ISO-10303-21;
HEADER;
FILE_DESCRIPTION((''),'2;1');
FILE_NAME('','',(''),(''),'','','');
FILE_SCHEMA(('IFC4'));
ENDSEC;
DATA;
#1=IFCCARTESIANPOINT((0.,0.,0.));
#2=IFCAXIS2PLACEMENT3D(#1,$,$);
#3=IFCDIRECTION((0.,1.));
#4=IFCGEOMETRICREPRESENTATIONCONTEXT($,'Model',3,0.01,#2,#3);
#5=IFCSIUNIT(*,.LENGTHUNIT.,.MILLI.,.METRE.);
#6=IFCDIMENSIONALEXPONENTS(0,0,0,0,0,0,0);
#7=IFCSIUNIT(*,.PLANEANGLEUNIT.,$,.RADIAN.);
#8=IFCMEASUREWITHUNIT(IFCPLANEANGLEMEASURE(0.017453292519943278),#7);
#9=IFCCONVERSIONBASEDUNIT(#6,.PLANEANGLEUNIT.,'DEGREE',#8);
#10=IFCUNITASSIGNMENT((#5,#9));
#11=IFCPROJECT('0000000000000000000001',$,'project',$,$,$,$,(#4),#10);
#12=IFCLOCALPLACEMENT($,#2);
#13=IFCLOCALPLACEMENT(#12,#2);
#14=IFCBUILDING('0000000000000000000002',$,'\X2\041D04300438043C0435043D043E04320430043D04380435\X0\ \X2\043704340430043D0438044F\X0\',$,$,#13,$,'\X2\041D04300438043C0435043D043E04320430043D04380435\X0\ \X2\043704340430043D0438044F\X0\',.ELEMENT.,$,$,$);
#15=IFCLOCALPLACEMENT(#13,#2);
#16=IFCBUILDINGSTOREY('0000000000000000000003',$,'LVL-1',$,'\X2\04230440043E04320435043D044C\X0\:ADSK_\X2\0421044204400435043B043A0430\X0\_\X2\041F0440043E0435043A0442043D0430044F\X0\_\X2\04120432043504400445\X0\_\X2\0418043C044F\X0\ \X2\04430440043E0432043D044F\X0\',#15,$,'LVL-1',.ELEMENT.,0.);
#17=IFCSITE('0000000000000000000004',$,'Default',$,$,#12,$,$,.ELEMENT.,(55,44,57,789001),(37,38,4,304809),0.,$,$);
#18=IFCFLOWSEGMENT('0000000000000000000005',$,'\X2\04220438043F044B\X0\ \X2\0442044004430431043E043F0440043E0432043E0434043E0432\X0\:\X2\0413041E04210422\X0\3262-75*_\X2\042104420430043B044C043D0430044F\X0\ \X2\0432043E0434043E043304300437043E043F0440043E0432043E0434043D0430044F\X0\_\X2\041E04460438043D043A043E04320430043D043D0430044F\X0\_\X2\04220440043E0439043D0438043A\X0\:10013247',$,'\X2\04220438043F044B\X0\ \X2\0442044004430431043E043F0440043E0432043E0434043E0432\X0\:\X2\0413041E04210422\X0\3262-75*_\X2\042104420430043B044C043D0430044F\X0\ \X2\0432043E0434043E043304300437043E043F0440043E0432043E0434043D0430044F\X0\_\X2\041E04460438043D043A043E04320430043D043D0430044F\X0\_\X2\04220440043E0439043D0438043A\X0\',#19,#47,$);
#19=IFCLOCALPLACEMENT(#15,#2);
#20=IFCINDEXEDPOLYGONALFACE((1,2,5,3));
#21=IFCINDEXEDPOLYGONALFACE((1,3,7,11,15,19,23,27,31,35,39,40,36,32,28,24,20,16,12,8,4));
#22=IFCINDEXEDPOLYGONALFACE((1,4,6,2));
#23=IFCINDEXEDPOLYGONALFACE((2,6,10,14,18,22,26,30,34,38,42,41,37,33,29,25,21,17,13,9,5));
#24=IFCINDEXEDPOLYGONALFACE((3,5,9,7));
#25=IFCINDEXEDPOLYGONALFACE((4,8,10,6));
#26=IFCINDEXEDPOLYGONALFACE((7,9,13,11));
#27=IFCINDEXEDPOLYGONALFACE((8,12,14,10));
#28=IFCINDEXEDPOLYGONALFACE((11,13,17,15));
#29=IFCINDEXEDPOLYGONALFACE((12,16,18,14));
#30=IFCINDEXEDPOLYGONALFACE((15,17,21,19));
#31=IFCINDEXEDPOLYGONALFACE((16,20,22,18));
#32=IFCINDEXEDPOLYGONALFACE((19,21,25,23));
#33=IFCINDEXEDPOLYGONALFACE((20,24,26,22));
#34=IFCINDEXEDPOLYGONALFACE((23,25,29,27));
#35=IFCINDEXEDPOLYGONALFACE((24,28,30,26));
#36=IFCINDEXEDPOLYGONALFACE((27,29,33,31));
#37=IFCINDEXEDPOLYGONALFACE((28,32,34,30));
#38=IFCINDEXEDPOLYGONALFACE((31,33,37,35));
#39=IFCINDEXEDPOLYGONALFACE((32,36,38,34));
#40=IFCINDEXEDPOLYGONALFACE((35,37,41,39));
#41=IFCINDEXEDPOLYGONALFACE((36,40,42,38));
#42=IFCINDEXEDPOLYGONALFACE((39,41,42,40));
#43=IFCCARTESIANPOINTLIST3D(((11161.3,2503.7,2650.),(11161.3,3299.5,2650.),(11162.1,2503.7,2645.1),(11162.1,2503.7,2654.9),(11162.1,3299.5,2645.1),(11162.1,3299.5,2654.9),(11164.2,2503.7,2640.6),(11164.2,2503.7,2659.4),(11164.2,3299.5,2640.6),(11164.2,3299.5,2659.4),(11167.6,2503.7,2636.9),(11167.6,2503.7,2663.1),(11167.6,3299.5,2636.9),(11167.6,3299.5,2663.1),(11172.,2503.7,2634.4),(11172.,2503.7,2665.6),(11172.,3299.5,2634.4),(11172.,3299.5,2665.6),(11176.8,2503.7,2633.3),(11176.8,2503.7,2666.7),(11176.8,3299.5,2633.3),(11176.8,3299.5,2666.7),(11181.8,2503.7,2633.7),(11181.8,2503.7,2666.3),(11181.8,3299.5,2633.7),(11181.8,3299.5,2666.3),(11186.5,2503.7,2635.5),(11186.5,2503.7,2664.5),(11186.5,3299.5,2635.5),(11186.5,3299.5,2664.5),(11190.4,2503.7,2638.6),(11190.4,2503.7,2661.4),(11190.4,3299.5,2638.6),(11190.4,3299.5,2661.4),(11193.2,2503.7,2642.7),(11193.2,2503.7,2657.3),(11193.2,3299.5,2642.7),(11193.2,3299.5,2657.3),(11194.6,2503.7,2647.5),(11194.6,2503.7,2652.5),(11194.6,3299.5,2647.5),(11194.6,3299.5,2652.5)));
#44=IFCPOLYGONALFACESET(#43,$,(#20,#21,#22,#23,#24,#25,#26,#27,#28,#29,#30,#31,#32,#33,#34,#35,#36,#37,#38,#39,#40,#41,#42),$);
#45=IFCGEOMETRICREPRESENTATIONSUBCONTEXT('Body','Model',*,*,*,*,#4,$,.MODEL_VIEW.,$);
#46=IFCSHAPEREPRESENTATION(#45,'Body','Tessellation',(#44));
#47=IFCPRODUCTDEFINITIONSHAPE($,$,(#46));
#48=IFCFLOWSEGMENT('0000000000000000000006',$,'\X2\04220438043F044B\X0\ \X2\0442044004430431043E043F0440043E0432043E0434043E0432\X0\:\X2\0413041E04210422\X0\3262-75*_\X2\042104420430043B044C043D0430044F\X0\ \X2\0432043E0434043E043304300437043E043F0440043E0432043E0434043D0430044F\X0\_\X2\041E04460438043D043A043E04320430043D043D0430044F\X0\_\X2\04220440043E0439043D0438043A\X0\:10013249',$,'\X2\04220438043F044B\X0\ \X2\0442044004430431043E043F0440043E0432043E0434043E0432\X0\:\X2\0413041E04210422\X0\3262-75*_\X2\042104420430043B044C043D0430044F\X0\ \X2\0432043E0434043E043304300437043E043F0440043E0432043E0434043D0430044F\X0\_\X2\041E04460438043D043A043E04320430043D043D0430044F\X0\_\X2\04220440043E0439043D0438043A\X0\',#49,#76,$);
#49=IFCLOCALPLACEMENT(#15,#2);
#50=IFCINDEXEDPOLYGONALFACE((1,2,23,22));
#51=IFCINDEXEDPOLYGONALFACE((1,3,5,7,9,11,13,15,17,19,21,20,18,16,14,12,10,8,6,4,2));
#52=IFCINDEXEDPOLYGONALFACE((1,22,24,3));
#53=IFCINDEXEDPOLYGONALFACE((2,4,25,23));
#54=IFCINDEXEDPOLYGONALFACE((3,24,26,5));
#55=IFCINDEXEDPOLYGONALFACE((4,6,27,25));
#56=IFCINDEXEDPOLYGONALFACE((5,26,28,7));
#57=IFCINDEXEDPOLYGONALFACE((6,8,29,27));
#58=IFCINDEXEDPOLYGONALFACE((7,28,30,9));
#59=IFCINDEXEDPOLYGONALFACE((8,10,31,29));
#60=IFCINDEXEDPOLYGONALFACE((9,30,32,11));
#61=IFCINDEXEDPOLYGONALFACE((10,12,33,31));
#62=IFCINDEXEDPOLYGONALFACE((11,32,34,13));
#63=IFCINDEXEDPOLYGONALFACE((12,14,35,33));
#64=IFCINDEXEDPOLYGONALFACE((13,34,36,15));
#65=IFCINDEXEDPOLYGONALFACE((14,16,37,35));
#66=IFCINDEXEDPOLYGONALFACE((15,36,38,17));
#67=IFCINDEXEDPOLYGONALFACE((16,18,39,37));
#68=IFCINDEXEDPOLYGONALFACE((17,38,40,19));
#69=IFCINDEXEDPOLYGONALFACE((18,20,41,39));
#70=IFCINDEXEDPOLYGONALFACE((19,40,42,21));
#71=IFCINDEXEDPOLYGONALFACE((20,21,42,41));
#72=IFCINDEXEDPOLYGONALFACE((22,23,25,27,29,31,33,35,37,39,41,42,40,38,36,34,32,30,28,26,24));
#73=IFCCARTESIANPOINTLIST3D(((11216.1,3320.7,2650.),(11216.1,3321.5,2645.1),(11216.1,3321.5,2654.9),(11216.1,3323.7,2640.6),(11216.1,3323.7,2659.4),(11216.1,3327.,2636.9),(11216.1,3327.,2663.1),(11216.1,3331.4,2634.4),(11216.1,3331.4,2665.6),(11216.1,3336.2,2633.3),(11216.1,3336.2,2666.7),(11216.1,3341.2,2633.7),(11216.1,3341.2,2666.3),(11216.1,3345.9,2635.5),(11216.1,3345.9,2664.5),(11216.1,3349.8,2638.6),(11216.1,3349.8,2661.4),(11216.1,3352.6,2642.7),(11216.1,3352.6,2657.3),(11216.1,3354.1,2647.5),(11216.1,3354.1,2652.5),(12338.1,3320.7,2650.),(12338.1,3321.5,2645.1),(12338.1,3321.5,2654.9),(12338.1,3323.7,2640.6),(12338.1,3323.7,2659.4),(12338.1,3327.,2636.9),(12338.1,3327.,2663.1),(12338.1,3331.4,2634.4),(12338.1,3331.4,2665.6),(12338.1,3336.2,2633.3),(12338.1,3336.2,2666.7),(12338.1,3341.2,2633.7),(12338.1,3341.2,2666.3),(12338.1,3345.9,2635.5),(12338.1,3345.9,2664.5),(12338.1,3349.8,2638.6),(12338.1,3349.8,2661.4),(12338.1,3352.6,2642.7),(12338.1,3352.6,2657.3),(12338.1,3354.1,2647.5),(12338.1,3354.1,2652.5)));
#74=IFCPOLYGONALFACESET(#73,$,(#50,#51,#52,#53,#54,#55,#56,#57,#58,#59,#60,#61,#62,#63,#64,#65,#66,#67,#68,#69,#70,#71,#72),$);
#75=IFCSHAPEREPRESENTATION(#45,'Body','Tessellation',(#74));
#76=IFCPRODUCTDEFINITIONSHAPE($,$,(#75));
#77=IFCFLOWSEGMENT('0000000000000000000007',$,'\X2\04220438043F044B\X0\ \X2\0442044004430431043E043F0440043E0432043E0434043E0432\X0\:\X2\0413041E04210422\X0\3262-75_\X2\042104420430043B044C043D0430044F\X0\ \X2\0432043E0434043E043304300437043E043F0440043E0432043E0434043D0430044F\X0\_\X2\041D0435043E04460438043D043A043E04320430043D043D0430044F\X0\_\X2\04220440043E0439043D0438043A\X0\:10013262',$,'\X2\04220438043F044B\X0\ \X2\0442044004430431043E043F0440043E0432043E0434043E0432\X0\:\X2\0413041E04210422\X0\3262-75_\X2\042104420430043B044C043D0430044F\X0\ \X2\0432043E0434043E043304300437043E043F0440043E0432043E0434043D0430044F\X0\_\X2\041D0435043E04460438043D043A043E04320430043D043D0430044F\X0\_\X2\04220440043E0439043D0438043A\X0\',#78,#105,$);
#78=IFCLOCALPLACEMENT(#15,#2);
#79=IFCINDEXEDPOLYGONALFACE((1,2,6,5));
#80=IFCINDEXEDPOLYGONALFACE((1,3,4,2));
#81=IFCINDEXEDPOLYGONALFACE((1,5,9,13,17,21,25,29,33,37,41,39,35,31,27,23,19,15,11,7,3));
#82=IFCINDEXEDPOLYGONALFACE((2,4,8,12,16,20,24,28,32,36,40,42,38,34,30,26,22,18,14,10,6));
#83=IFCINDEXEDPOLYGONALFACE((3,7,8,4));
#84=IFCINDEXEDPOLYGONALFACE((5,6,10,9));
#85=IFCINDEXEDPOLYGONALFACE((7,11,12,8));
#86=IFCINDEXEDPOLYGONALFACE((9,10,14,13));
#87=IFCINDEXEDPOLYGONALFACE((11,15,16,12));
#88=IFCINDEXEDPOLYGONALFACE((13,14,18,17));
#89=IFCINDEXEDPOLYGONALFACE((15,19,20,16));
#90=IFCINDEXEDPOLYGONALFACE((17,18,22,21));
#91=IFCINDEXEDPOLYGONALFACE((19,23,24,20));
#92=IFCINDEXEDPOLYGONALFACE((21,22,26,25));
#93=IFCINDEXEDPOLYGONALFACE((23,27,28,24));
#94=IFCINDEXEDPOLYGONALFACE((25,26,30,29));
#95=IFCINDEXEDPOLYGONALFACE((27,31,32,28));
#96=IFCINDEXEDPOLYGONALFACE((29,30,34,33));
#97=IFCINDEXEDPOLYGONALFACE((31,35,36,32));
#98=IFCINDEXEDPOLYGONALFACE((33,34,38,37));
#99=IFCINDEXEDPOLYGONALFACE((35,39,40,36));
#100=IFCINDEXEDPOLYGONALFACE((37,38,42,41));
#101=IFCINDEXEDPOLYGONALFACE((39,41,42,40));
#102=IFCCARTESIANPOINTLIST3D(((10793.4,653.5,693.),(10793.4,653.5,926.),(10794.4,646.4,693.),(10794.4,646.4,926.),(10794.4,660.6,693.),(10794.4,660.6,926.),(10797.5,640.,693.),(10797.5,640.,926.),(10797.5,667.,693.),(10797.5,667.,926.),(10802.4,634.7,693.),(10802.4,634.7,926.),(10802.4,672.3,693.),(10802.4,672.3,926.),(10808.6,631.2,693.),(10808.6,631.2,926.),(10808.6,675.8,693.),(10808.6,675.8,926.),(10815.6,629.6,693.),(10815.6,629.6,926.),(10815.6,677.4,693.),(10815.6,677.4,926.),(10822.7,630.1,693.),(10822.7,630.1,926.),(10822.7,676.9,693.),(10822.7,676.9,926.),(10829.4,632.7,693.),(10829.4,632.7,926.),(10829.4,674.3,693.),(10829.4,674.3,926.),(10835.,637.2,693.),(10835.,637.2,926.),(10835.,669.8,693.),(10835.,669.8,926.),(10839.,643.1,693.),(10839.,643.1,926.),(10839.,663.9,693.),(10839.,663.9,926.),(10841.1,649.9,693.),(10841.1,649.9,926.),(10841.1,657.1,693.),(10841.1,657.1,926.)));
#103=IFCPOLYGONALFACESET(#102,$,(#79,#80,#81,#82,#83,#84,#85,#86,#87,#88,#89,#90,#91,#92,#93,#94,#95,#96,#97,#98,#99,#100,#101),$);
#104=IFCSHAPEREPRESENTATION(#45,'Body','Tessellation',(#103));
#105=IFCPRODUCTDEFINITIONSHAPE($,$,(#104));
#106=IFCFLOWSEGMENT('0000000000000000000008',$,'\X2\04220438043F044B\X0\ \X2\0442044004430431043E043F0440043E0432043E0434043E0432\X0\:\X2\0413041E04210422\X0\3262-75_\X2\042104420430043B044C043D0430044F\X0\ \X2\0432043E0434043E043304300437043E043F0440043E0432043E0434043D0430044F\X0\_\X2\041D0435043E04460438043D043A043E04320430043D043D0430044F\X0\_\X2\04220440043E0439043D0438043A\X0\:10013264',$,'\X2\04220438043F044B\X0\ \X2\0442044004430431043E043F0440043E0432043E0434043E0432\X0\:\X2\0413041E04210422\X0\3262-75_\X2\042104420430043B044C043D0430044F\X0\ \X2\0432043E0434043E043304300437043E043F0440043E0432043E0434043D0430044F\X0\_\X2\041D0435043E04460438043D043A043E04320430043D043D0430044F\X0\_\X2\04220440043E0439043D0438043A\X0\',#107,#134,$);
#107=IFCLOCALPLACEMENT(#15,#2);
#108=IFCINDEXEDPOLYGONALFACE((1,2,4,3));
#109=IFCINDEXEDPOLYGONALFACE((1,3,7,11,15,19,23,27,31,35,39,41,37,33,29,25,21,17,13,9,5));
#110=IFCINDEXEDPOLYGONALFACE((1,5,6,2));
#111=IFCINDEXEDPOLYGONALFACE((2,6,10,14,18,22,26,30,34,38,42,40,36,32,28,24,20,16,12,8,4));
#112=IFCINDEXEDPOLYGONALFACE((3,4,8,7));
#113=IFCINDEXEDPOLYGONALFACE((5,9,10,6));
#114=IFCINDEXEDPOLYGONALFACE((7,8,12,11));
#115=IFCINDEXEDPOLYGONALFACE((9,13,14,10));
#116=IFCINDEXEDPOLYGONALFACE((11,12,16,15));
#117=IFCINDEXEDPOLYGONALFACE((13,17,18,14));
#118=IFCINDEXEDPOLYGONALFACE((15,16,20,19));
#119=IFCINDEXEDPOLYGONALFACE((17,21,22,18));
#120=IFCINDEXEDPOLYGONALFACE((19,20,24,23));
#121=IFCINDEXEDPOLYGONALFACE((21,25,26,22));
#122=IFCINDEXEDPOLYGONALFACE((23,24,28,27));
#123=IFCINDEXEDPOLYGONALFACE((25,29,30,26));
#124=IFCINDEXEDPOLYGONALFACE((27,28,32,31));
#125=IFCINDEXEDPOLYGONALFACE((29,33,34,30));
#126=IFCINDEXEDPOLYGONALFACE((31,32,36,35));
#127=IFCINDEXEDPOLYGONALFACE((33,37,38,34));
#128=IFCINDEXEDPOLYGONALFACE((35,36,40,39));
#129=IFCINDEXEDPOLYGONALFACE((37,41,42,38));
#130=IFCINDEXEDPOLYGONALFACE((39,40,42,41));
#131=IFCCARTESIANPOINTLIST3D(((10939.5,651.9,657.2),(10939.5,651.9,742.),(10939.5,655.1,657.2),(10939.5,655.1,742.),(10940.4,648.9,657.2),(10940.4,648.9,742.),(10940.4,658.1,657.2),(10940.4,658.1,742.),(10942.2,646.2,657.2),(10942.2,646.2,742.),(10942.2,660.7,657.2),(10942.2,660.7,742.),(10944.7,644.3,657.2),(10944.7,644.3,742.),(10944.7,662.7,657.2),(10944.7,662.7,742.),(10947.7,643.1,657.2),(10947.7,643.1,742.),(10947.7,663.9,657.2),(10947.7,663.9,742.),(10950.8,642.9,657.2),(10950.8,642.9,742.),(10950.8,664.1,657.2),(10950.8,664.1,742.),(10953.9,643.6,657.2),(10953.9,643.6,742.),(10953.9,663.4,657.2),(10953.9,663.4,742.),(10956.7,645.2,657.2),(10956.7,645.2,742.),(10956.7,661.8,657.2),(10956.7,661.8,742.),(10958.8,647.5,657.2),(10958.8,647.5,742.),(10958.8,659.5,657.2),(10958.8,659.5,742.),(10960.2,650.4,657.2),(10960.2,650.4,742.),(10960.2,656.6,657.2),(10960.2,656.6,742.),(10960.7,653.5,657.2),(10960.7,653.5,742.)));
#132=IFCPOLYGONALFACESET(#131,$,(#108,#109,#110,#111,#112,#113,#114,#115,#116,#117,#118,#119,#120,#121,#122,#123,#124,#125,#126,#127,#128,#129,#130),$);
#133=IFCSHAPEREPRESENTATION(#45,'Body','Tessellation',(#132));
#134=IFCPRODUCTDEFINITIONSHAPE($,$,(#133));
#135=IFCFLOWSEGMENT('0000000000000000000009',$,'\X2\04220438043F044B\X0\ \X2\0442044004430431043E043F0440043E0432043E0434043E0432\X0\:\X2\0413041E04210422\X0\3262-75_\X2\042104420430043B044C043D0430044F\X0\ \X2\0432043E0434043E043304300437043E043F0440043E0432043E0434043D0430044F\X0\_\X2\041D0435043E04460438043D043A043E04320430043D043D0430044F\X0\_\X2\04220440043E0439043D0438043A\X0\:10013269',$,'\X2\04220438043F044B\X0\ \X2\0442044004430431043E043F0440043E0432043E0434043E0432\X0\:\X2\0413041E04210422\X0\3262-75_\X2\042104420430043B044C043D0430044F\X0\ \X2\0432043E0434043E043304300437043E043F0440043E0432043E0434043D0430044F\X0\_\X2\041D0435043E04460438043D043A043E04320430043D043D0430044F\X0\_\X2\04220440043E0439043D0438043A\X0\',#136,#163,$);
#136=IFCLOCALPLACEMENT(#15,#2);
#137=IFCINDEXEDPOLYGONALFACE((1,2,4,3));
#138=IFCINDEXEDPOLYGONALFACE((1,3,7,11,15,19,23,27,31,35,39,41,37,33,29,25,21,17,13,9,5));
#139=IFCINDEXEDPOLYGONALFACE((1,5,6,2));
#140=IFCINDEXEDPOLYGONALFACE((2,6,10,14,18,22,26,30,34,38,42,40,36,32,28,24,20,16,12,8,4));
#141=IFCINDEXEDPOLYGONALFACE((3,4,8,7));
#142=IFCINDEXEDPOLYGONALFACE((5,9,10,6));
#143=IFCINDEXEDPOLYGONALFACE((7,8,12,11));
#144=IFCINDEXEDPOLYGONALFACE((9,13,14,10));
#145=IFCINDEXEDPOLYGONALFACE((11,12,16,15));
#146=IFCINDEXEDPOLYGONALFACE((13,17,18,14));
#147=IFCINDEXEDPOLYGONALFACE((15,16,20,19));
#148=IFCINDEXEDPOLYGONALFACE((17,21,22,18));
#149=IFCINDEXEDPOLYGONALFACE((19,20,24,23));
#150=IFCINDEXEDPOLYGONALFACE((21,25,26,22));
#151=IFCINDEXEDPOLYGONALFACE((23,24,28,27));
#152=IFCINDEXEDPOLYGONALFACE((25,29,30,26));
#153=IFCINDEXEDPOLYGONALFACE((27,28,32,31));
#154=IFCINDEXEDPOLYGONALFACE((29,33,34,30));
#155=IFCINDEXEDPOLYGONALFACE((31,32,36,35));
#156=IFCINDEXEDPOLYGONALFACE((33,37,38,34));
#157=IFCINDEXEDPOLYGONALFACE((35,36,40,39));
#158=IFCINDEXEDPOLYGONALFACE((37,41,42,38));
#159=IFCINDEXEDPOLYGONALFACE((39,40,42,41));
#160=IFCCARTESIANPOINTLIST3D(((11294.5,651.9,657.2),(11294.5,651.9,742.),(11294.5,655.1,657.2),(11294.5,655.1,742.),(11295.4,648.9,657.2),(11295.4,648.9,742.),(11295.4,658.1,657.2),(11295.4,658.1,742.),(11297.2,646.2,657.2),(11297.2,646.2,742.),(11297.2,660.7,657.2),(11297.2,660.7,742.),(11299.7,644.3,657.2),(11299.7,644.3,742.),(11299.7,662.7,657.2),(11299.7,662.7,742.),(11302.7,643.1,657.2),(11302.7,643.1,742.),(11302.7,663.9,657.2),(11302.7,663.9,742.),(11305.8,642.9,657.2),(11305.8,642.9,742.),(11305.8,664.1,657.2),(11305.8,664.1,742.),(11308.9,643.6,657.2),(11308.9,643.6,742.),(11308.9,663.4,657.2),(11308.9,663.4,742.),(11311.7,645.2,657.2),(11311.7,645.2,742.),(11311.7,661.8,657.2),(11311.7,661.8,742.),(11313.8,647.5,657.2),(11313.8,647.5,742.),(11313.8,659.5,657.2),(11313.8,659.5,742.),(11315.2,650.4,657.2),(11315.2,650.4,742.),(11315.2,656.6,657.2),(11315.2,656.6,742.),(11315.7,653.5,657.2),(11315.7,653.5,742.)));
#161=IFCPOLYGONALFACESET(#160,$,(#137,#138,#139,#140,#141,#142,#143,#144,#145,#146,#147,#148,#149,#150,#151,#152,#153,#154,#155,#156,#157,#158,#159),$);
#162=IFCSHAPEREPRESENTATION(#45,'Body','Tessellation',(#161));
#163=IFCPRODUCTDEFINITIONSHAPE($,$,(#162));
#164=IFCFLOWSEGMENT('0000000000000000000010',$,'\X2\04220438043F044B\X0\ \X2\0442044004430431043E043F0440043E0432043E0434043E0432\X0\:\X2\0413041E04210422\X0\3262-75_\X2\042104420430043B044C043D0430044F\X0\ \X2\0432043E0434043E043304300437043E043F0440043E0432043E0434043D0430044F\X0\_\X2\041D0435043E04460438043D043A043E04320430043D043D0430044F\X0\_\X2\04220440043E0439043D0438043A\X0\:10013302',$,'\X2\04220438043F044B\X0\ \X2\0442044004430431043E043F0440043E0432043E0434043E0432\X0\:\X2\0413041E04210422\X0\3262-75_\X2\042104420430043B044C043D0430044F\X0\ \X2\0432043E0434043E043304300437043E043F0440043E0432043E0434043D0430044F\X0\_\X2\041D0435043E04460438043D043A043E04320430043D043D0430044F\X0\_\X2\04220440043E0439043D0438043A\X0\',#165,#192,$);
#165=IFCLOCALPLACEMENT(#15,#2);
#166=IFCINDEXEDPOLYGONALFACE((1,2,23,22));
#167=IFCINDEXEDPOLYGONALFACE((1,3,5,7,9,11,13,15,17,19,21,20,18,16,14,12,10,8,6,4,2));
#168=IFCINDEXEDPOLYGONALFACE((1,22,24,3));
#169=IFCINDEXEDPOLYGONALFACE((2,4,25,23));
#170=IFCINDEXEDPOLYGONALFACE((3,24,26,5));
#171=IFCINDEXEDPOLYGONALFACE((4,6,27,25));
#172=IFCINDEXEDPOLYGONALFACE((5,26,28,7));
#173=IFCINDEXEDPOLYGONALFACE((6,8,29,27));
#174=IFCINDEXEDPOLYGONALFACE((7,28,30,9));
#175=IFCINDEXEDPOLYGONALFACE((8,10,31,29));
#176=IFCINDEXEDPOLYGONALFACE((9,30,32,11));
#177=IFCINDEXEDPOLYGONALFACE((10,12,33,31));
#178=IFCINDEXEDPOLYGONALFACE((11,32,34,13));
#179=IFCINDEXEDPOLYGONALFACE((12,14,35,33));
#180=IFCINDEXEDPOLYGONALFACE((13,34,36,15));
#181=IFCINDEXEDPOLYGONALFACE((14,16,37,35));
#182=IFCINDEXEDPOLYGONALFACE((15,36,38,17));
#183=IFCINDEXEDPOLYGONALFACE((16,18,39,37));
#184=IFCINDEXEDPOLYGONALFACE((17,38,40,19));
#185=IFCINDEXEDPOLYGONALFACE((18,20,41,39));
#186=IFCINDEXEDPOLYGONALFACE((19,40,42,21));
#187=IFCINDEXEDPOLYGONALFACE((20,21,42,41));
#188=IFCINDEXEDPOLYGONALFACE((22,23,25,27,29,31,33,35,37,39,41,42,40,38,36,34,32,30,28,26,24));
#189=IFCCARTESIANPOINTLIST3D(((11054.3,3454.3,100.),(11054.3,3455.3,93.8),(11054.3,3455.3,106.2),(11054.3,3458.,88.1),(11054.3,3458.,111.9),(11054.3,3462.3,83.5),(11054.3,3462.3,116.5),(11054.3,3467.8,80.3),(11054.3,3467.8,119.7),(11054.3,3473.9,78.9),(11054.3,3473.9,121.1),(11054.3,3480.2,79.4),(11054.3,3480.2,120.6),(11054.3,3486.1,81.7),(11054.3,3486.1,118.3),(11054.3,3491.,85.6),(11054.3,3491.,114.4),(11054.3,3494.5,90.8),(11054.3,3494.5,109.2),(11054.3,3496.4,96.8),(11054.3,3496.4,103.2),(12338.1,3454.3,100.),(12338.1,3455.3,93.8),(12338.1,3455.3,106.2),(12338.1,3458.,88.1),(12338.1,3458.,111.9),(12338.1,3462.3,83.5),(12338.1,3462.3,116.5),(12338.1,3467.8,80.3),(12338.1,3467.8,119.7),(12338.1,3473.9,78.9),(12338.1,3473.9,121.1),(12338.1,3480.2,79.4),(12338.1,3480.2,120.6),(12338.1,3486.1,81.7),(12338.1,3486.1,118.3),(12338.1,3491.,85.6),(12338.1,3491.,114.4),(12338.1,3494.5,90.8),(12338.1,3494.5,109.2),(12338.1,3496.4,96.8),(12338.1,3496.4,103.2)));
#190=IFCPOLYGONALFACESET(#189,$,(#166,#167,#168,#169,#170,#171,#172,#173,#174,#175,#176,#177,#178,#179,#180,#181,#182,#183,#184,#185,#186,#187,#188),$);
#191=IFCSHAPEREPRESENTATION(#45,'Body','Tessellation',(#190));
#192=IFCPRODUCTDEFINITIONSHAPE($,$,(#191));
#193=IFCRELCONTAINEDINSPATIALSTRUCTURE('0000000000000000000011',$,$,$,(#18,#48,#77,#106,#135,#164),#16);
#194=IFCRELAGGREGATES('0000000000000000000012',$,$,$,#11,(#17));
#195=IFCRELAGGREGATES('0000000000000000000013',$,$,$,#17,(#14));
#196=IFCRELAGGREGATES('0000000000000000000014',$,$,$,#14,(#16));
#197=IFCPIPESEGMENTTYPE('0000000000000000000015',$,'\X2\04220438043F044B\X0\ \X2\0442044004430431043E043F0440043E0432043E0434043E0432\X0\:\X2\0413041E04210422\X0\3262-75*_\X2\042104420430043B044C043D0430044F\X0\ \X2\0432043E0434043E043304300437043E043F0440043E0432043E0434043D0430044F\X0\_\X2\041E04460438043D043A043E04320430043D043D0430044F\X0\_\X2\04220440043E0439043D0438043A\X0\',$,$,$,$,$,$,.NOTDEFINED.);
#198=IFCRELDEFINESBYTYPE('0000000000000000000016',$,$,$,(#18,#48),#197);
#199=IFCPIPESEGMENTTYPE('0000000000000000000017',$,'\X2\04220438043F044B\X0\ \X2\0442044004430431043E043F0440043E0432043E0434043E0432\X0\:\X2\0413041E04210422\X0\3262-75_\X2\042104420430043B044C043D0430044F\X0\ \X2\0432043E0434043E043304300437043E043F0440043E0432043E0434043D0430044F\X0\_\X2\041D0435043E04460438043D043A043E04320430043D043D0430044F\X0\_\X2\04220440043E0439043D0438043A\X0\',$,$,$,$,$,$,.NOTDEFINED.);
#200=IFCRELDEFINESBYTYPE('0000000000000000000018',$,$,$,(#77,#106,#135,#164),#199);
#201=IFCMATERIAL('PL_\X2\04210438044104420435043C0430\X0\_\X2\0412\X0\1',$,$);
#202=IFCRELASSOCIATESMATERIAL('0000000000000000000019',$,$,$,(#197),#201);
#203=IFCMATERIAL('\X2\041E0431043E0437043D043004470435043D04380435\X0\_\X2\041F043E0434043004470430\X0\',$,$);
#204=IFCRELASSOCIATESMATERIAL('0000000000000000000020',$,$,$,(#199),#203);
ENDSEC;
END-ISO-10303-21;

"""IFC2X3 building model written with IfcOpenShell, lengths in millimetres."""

from ifc_helpers import new_model, entity, si_unit, converted_unit, direction, frame, frame_2d, origin, origin_2d_with_axis, place, context, subcontext, project, spatial, circle, extrude, material, type_object, element, save


model = new_model("IFC2X3")

# Units and contexts
model_context = context("Model", 3, precision=0.01, world=origin(), true_north=direction((0.0, 1.0)))
body_context = subcontext(model_context, "Body", "Model", "MODEL_VIEW")
ifc_project = project(units=[si_unit("LENGTHUNIT", "METRE", prefix="MILLI"), converted_unit("PLANEANGLEUNIT", "DEGREE", entity("IfcPlaneAngleMeasure", 0.017453292519943278), si_unit("PLANEANGLEUNIT", "RADIAN"), dimensions=[0, 0, 0, 0, 0, 0, 0])], contexts=[model_context])

# Site, building, storey
site_placement = place(None, origin())
site = spatial("IfcSite", under=ifc_project, at=site_placement, Name="Default", CompositionType="ELEMENT", RefLatitude=(55, 44, 57, 789001), RefLongitude=(37, 38, 4, 304809), RefElevation=0.0)
building_placement = place(site_placement, origin())
building = spatial("IfcBuilding", under=site, at=building_placement, Name="Наименование здания", LongName="Наименование здания", CompositionType="ELEMENT")
storey_placement = place(building_placement, origin())
storey = spatial("IfcBuildingStorey", under=building, at=storey_placement, Name="LVL-1", ObjectType="Уровень:ADSK_Стрелка_Проектная_Вверх_Имя уровня", LongName="LVL-1", CompositionType="ELEMENT", Elevation=0.0)

# Flow segments
ifc_material_1 = material(Name="PL_Система_В1")
pipe_segment_type_1 = type_object("IfcPipeSegmentType", Name="Типы трубопроводов:ГОСТ3262-75*_Стальная водогазопроводная_Оцинкованная_Тройник", PredefinedType="NOTDEFINED", material=ifc_material_1)
flow_segment_1_placement = place(storey_placement, origin())
element("IfcFlowSegment", 1, at=flow_segment_1_placement, inside=storey, type_object=pipe_segment_type_1, Name="Типы трубопроводов:ГОСТ3262-75*_Стальная водогазопроводная_Оцинкованная_Тройник:10013247", ObjectType="Типы трубопроводов:ГОСТ3262-75*_Стальная водогазопроводная_Оцинкованная_Тройник", context=body_context, shape_type="SweptSolid", body=[
    extrude(circle(Radius=16.8, at=frame_2d((0.0, 0.0), x_axis=(1.0, 0.0))), frame((11178.1, 2503.7, 2650.0), z_axis=(0.0, 1.0, 0.0), x_axis=(-1.0, 0.0, 0.0)), (0.0, 0.0, 1.0), 795.8),
])
flow_segment_2_placement = place(storey_placement, origin())
element("IfcFlowSegment", 2, at=flow_segment_2_placement, inside=storey, type_object=pipe_segment_type_1, Name="Типы трубопроводов:ГОСТ3262-75*_Стальная водогазопроводная_Оцинкованная_Тройник:10013249", ObjectType="Типы трубопроводов:ГОСТ3262-75*_Стальная водогазопроводная_Оцинкованная_Тройник", context=body_context, shape_type="SweptSolid", body=[
    extrude(circle(Radius=16.8, at=origin_2d_with_axis()), frame((11216.1, 3337.5, 2650.0), z_axis=(1.0, 0.0, 0.0), x_axis=(0.0, -1.0, 0.0)), (0.0, 0.0, 1.0), 1122.0),
])
ifc_material_2 = material(Name="Обозначение_Подача")
pipe_segment_type_2 = type_object("IfcPipeSegmentType", Name="Типы трубопроводов:ГОСТ3262-75_Стальная водогазопроводная_Неоцинкованная_Тройник", PredefinedType="NOTDEFINED", material=ifc_material_2)
flow_segment_3_placement = place(storey_placement, origin())
element("IfcFlowSegment", 3, at=flow_segment_3_placement, inside=storey, type_object=pipe_segment_type_2, Name="Типы трубопроводов:ГОСТ3262-75_Стальная водогазопроводная_Неоцинкованная_Тройник:10013262", ObjectType="Типы трубопроводов:ГОСТ3262-75_Стальная водогазопроводная_Неоцинкованная_Тройник", context=body_context, shape_type="SweptSolid", body=[
    extrude(circle(Radius=24.0, at=origin_2d_with_axis()), frame((10817.4, 653.5, 693.0), z_axis=(0.0, 0.0, 1.0), x_axis=(-1.0, 0.0, 0.0)), (0.0, 0.0, 1.0), 233.0),
])
flow_segment_4_placement = place(storey_placement, origin())
element("IfcFlowSegment", 4, at=flow_segment_4_placement, inside=storey, type_object=pipe_segment_type_2, Name="Типы трубопроводов:ГОСТ3262-75_Стальная водогазопроводная_Неоцинкованная_Тройник:10013264", ObjectType="Типы трубопроводов:ГОСТ3262-75_Стальная водогазопроводная_Неоцинкованная_Тройник", context=body_context, shape_type="SweptSolid", body=[
    extrude(circle(Radius=10.7, at=origin_2d_with_axis()), frame((10950.0, 653.5, 657.2)), (0.0, 0.0, 1.0), 84.8),
])
flow_segment_5_placement = place(storey_placement, origin())
element("IfcFlowSegment", 5, at=flow_segment_5_placement, inside=storey, type_object=pipe_segment_type_2, Name="Типы трубопроводов:ГОСТ3262-75_Стальная водогазопроводная_Неоцинкованная_Тройник:10013269", ObjectType="Типы трубопроводов:ГОСТ3262-75_Стальная водогазопроводная_Неоцинкованная_Тройник", context=body_context, shape_type="SweptSolid", body=[
    extrude(circle(Radius=10.7, at=origin_2d_with_axis()), frame((11305.0, 653.5, 657.2)), (0.0, 0.0, 1.0), 84.8),
])
flow_segment_6_placement = place(storey_placement, origin())
element("IfcFlowSegment", 6, at=flow_segment_6_placement, inside=storey, type_object=pipe_segment_type_2, Name="Типы трубопроводов:ГОСТ3262-75_Стальная водогазопроводная_Неоцинкованная_Тройник:10013302", ObjectType="Типы трубопроводов:ГОСТ3262-75_Стальная водогазопроводная_Неоцинкованная_Тройник", context=body_context, shape_type="SweptSolid", body=[
    extrude(circle(Radius=21.1, at=frame_2d((0.0, 0.0), x_axis=(1.0, 0.0))), frame((11054.3, 3475.5, 100.0), z_axis=(1.0, 0.0, 0.0), x_axis=(0.0, -1.0, 0.0)), (0.0, 0.0, 1.0), 1283.8),
])

save(model, "model.ifc")
